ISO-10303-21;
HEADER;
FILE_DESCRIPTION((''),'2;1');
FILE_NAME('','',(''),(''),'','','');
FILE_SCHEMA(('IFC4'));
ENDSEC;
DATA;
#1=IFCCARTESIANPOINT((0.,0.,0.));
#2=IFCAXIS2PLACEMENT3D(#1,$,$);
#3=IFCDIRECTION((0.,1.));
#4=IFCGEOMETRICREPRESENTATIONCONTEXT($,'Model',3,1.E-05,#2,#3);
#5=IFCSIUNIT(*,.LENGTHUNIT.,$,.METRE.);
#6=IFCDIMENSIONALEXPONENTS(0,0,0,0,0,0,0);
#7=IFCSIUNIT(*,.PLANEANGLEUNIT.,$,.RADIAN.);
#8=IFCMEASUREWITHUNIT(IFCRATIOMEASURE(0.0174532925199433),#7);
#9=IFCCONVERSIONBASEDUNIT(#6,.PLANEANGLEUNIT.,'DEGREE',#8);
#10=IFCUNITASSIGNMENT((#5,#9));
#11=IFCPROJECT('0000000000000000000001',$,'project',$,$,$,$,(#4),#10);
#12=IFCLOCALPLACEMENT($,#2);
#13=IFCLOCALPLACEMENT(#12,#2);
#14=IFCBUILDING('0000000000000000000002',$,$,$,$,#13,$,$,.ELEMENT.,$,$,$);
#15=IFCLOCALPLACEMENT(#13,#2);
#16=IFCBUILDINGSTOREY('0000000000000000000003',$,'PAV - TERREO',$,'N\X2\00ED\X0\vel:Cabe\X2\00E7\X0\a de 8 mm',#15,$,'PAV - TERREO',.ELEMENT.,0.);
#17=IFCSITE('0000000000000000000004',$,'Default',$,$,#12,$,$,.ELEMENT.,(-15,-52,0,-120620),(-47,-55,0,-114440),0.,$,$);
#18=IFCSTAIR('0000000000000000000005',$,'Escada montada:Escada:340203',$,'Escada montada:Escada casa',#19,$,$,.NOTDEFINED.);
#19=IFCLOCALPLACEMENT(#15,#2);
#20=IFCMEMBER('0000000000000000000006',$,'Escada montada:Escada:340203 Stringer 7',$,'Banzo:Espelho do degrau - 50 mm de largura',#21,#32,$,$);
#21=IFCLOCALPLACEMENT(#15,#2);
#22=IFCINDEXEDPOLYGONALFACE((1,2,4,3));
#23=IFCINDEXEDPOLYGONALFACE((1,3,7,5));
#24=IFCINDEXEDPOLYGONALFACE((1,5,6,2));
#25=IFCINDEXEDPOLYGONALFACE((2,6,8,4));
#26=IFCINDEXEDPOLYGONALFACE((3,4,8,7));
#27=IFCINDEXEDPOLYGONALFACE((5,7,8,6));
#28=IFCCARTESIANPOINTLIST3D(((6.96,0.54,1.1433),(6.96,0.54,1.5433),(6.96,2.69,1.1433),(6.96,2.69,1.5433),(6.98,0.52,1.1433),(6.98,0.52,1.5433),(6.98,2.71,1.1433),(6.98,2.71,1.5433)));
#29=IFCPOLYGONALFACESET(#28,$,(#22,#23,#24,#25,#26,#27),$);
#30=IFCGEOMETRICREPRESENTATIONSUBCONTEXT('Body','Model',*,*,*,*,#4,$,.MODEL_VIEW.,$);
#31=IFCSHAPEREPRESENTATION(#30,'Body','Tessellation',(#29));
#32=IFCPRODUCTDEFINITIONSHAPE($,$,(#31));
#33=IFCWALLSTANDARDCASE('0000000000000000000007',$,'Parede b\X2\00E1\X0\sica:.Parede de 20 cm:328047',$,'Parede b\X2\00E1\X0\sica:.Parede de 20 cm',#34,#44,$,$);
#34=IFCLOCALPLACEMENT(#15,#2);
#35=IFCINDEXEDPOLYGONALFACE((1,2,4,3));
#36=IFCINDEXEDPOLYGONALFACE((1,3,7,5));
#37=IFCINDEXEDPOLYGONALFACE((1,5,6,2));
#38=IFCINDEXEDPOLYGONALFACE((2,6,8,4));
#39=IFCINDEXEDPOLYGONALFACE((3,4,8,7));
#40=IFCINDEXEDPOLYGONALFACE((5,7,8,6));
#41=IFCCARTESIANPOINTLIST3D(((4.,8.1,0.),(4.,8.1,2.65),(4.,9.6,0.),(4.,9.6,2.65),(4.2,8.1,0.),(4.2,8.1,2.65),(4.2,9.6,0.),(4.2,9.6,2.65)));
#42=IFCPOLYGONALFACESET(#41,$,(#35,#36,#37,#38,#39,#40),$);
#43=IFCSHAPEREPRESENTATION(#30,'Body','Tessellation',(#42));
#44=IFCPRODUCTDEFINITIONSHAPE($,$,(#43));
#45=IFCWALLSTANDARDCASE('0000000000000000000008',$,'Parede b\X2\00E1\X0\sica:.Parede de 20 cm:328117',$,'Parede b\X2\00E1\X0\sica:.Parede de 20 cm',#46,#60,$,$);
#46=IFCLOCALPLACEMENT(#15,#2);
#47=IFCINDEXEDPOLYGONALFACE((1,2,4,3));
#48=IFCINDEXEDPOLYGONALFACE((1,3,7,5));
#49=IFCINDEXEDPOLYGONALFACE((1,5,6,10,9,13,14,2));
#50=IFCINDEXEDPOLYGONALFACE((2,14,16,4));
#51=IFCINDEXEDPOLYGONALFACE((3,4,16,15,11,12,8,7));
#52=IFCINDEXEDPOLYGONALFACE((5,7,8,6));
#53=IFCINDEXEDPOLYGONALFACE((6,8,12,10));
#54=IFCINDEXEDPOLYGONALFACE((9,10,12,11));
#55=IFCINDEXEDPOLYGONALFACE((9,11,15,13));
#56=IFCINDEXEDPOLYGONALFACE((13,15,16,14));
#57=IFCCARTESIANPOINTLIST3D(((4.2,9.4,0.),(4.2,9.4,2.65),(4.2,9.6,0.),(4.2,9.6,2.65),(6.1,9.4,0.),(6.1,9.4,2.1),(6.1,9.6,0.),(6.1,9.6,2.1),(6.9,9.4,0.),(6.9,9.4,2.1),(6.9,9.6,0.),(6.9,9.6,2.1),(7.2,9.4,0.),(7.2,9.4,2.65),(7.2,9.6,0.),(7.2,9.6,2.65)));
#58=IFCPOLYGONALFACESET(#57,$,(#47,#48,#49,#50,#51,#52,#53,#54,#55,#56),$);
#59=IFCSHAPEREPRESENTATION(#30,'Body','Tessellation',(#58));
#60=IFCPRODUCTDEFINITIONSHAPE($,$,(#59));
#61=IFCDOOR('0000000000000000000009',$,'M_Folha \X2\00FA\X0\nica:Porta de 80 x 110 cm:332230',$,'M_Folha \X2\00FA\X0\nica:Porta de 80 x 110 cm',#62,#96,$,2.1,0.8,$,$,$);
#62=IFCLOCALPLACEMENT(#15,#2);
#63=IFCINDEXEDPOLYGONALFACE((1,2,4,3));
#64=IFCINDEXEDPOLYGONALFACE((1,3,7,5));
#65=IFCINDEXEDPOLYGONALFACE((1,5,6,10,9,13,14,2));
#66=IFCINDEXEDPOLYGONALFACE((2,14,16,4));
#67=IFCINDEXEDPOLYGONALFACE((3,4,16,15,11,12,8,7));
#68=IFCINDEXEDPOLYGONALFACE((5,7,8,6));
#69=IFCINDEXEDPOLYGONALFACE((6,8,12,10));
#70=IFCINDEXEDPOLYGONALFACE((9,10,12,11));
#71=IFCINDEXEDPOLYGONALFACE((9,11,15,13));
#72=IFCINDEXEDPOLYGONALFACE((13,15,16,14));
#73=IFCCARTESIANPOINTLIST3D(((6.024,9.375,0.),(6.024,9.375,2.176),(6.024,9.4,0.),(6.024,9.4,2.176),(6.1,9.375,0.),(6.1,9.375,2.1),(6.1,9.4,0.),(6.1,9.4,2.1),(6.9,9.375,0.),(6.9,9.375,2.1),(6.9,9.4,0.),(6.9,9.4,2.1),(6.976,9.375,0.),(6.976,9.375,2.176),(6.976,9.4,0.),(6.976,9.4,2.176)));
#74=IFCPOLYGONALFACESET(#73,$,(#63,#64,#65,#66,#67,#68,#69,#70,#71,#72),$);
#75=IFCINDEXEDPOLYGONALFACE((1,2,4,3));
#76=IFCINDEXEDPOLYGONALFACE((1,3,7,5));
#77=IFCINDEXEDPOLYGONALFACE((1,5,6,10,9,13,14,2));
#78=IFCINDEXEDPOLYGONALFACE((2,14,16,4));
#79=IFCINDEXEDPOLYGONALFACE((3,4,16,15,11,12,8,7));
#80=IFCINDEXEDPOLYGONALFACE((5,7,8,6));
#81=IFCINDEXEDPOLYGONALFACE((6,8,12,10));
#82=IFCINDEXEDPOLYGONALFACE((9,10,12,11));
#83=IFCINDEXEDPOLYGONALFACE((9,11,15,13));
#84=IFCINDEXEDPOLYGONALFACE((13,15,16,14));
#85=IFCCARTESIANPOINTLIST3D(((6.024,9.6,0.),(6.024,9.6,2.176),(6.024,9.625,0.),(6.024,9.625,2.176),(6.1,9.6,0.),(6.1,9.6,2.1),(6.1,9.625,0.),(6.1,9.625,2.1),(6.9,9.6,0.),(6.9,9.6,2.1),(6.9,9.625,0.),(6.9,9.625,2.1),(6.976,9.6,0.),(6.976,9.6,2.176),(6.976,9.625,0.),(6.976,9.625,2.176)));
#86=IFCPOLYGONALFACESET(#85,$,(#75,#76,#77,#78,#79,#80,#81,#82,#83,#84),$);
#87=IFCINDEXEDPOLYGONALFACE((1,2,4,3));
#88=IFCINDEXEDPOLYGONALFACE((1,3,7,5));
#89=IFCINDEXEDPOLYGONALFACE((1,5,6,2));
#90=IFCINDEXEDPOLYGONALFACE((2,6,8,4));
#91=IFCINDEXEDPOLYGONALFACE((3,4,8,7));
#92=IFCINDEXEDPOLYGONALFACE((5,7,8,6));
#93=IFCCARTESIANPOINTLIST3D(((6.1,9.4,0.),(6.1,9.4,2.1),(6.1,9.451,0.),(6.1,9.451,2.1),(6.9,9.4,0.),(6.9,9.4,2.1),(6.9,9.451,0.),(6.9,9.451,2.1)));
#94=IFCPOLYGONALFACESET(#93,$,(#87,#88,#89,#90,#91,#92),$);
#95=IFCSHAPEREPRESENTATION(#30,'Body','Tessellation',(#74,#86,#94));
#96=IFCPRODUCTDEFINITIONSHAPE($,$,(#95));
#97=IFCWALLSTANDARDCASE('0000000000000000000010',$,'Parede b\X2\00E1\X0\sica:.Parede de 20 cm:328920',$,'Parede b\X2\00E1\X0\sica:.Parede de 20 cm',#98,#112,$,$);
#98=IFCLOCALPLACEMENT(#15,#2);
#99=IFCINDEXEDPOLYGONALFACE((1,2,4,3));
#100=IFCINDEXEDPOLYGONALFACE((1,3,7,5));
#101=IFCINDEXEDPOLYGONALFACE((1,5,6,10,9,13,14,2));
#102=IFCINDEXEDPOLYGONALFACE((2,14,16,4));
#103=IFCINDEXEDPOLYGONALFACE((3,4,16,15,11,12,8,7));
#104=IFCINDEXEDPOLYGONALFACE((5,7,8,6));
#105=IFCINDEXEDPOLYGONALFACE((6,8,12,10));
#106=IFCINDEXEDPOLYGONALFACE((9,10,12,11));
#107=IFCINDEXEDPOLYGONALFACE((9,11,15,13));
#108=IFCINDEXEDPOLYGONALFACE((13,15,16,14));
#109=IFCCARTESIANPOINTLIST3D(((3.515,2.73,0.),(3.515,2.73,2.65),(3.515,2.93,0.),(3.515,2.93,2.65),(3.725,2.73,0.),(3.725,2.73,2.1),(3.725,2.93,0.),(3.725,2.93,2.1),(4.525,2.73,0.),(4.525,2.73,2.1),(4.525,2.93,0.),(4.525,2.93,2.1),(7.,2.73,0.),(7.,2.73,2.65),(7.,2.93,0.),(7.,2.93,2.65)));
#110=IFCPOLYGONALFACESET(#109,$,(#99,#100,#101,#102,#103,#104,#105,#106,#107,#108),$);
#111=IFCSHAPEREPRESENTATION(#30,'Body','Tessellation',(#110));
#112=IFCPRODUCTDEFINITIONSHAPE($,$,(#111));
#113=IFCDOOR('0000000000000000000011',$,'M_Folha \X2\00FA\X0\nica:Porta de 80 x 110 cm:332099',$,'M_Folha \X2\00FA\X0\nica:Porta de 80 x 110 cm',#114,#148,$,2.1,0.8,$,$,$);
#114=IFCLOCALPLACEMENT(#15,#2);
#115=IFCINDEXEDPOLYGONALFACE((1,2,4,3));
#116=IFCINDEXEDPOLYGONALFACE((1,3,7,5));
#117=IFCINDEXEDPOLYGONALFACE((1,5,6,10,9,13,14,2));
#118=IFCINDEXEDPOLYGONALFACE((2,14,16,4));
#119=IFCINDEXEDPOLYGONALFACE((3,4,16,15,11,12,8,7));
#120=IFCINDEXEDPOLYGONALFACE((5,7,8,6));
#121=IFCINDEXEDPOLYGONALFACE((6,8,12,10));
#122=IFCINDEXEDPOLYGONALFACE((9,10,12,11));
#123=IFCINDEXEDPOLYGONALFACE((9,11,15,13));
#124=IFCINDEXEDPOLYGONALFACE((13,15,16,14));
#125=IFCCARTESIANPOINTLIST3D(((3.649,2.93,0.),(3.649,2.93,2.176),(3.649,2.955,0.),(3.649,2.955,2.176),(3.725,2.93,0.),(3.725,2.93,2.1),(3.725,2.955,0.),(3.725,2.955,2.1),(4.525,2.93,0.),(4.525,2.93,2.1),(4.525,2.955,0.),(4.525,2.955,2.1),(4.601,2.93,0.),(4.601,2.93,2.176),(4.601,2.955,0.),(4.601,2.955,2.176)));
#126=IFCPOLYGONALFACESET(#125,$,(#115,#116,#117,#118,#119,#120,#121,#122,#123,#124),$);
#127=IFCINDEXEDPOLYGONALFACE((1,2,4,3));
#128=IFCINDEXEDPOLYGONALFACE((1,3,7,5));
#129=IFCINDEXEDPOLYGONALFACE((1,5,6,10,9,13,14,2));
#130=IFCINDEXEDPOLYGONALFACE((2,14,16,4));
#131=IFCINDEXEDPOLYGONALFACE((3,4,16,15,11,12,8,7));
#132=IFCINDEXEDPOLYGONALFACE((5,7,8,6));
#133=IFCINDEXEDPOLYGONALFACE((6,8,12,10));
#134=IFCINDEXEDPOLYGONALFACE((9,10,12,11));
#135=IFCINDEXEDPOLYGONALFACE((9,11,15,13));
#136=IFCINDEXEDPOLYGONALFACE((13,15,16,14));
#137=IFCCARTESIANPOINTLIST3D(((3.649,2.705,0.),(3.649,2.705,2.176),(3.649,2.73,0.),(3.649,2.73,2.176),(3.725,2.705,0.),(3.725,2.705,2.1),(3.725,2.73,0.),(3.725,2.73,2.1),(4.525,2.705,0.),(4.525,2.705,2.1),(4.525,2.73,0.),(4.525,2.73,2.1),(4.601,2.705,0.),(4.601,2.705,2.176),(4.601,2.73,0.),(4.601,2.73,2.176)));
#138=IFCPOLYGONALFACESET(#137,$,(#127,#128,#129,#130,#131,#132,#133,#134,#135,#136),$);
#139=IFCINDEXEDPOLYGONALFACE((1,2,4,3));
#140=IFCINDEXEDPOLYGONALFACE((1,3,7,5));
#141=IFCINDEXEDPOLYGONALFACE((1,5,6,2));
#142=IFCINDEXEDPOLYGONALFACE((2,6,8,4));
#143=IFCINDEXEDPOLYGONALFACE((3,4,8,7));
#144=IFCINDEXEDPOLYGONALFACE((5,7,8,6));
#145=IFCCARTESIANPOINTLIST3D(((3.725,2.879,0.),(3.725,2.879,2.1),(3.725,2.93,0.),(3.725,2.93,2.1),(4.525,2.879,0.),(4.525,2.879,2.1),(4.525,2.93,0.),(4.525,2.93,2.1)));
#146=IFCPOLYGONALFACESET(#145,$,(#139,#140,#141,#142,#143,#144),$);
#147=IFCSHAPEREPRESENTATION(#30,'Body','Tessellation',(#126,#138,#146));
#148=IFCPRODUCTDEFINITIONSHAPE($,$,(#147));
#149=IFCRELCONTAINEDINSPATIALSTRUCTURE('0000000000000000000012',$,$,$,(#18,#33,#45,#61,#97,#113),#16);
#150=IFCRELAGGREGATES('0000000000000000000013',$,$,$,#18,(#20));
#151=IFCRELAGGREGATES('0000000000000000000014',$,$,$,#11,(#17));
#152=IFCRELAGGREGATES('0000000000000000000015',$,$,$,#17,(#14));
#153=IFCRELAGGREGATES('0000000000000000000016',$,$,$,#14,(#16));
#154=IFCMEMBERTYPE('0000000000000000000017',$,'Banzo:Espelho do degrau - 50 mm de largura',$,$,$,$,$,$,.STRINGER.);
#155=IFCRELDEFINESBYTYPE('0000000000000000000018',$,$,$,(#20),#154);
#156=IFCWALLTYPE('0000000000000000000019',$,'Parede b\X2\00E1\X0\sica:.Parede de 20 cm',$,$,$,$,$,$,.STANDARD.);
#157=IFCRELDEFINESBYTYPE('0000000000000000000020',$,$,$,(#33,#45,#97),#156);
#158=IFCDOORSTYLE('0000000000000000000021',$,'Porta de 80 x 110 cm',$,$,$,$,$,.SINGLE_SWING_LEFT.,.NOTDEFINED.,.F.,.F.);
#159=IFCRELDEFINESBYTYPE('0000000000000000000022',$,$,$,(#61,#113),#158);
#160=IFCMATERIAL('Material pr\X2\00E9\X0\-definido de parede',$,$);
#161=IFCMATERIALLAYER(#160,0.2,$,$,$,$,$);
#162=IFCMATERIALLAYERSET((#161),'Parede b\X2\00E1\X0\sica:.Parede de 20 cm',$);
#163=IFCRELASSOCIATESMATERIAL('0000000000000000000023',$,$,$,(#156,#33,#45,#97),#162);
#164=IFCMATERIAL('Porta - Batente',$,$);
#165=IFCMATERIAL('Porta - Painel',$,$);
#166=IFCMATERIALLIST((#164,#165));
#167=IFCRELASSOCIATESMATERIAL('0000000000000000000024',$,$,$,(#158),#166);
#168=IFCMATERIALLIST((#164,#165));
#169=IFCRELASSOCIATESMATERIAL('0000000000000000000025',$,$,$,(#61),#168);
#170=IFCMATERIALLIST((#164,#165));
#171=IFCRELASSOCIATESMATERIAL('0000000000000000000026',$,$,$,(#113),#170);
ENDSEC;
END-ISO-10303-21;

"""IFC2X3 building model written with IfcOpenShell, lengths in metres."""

from ifc_helpers import new_model, entity, si_unit, converted_unit, direction, frame, frame_2d, origin, place, context, subcontext, project, spatial, polyline, rectangle, outline, extrude, clip, bounded_halfspace, source, transform, mapped, material, material_list, layer, layer_set, layer_usage, type_object, type_shapes, element, fill, aggregate, save


model = new_model("IFC2X3")

# Units and contexts
model_context = context("Model", 3, precision=1e-05, world=origin(), true_north=direction((0.0, 1.0)))
body_context = subcontext(model_context, "Body", "Model", "MODEL_VIEW")
ifc_project = project(units=[si_unit("LENGTHUNIT", "METRE"), converted_unit("PLANEANGLEUNIT", "DEGREE", entity("IfcRatioMeasure", 0.0174532925199433), si_unit("PLANEANGLEUNIT", "RADIAN"), dimensions=[0, 0, 0, 0, 0, 0, 0])], contexts=[model_context])

# Site, building, storey
site_placement = place(None, origin())
site = spatial("IfcSite", under=ifc_project, at=site_placement, Name="Default", CompositionType="ELEMENT", RefLatitude=(-15, -52, 0, -120620), RefLongitude=(-47, -55, 0, -114440), RefElevation=0.0)
building_placement = place(site_placement, origin())
building = spatial("IfcBuilding", under=site, at=building_placement, CompositionType="ELEMENT")
storey_placement = place(building_placement, origin())
storey = spatial("IfcBuildingStorey", under=building, at=storey_placement, Name="PAV - TERREO", ObjectType="Nível:Cabeça de 8 mm", LongName="PAV - TERREO", CompositionType="ELEMENT", Elevation=0.0)

# Stair, member
stair_placement = place(storey_placement, origin())
stair = element("IfcStair", 1, at=stair_placement, inside=storey, Name="Escada montada:Escada:340203", ObjectType="Escada montada:Escada casa", ShapeType="NOTDEFINED")
member_type = type_object("IfcMemberType", Name="Banzo:Espelho do degrau - 50 mm de largura", PredefinedType="STRINGER")
member_placement = place(stair_placement, origin())
member = element("IfcMember", 2, at=member_placement, type_object=member_type, Name="Escada montada:Escada:340203 Stringer 7", ObjectType="Banzo:Espelho do degrau - 50 mm de largura", context=body_context, shape_type="SweptSolid", body=[
    extrude(outline(polyline([(-1.095, -0.01), (1.095, -0.01), (1.075, 0.01), (-1.075, 0.01), (-1.095, -0.01)])), frame((6.97, 1.615, 1.1433), z_axis=(0.0, 0.0, 1.0), x_axis=(0.0, 1.0, 0.0)), (0.0, 0.0, 1.0), 0.4),
])
aggregate(stair, [member])

# Shared definitions
ifc_material_1 = material(Name="Material pré-definido de parede")
ifc_layer_1 = layer(ifc_material_1, 0.2)
ifc_layer_set_1 = layer_set([ifc_layer_1], Name="Parede básica:.Parede de 20 cm")
wall_type_1 = type_object("IfcWallType", Name="Parede básica:.Parede de 20 cm", PredefinedType="STANDARD", material=ifc_layer_set_1)
ifc_material_2 = material(Name="Porta - Batente")
ifc_material_3 = material(Name="Porta - Painel")
ifc_material_list_1 = material_list([ifc_material_2, ifc_material_3])
door_style_1 = type_object("IfcDoorStyle", Name="Porta de 80 x 110 cm", ConstructionType="NOTDEFINED", OperationType="SINGLE_SWING_LEFT", ParameterTakesPrecedence=False, Sizeable=False, material=ifc_material_list_1)
shared_shape_1 = source(origin(), body_context, "Body", "SweptSolid", [
    extrude(outline(polyline([(-0.476, -1.107), (0.476, -1.107), (0.476, 1.069), (0.4, 1.069), (0.4, -1.031), (-0.4, -1.031), (-0.4, 1.069), (-0.476, 1.069), (-0.476, -1.107)])), frame((0.4, 0.225, 1.069), z_axis=(0.0, -1.0, 0.0), x_axis=(-1.0, 0.0, 0.0)), (0.0, 0.0, 1.0), 0.025),
    extrude(outline(polyline([(-1.107, -0.476), (1.069, -0.476), (1.069, -0.4), (-1.031, -0.4), (-1.031, 0.4), (1.069, 0.4), (1.069, 0.476), (-1.107, 0.476), (-1.107, -0.476)])), frame((0.4, 0.0, 1.069), z_axis=(0.0, -1.0, 0.0), x_axis=(0.0, 0.0, -1.0)), (0.0, 0.0, 1.0), 0.025),
    extrude(rectangle(XDim=0.8, YDim=0.051, at=frame_2d((0.0, 0.0), x_axis=(1.0, 0.0))), frame((0.4, 0.1745, 0.0)), (0.0, 0.0, 1.0), 2.1),
])
type_shapes(door_style_1, [shared_shape_1])

# Wall
ifc_layer_usage_1 = layer_usage(ifc_layer_set_1, "AXIS2", "NEGATIVE", 0.1)
wall_1_placement = place(storey_placement, frame((4.1, 8.1, 0.0), z_axis=(0.0, 0.0, 1.0), x_axis=(0.0, 1.0, 0.0)))
element("IfcWallStandardCase", 3, at=wall_1_placement, inside=storey, type_object=wall_type_1, material=ifc_layer_usage_1, Name="Parede básica:.Parede de 20 cm:328047", ObjectType="Parede básica:.Parede de 20 cm", context=body_context, shape_type="Clipping", body=[
    clip(extrude(rectangle(XDim=1.5, YDim=0.2, at=frame_2d((0.75, 0.0), x_axis=(-1.0, 0.0))), origin(), (0.0, 0.0, 1.0), 2.65), bounded_halfspace(frame((0.0, -0.1, 2.65), z_axis=(0.0, 0.0, -1.0), x_axis=(-1.0, 0.0, 0.0)), True, frame((0.0, -0.1, 2.65)), polyline([(0.0, 0.0), (1.3, 0.0), (1.5, 0.0), (1.5, 0.2), (0.0, 0.2), (0.0, 0.0)]))),
])

# Wall, opening, door
ifc_layer_usage_2 = layer_usage(ifc_layer_set_1, "AXIS2", "NEGATIVE", 0.1)
wall_2_placement = place(storey_placement, frame((4.2, 9.5, 0.0)))
wall_2 = element("IfcWallStandardCase", 4, at=wall_2_placement, inside=storey, type_object=wall_type_1, material=ifc_layer_usage_2, Name="Parede básica:.Parede de 20 cm:328117", ObjectType="Parede básica:.Parede de 20 cm", context=body_context, shape_type="Clipping", body=[
    clip(extrude(rectangle(XDim=3.0, YDim=0.2, at=frame_2d((1.5, 0.0), x_axis=(-1.0, 0.0))), origin(), (0.0, 0.0, 1.0), 2.65), bounded_halfspace(frame((0.0, -0.1, 2.65), z_axis=(0.0, 0.0, -1.0), x_axis=(0.0, -1.0, 0.0)), True, frame((0.0, -0.1, 2.65)), polyline([(0.0, 0.0), (2.8, 0.0), (3.0, 0.0), (3.0, 0.2), (0.0, 0.2), (0.0, 0.0)]))),
])
opening_1_placement = place(wall_2_placement, frame((2.7, 0.1, 0.0)))
opening_1 = element("IfcOpeningElement", 5, at=opening_1_placement, cuts=wall_2, ObjectType="Opening", context=body_context, shape_type="SweptSolid", body=[
    extrude(rectangle(XDim=0.8, YDim=2.1, at=frame_2d((1.05, 0.4), x_axis=(0.0, -1.0))), frame((0.0, 0.0, 0.0), z_axis=(0.0, -1.0, 0.0), x_axis=(0.0, 0.0, 1.0)), (0.0, 0.0, 1.0), 0.2),
])
ifc_material_list_2 = material_list([ifc_material_2, ifc_material_3])
door_1_placement = place(opening_1_placement, frame((0.0, 0.0, 0.0), z_axis=(0.0, 0.0, 1.0), x_axis=(-1.0, 0.0, 0.0)))
door_1 = element("IfcDoor", 6, at=door_1_placement, inside=storey, type_object=door_style_1, material=ifc_material_list_2, Name="M_Folha única:Porta de 80 x 110 cm:332230", ObjectType="M_Folha única:Porta de 80 x 110 cm", OverallHeight=2.1, OverallWidth=0.8, context=body_context, shape_type="MappedRepresentation", body=[
    mapped(shared_shape_1, transform((0.0, 0.0, 0.0), scale=1.0)),
])
fill(opening_1, door_1)

# Wall, opening, door
ifc_layer_usage_3 = layer_usage(ifc_layer_set_1, "AXIS2", "NEGATIVE", 0.1)
wall_3_placement = place(storey_placement, frame((7.0, 2.83, 0.0), z_axis=(0.0, 0.0, 1.0), x_axis=(-1.0, 0.0, 0.0)))
wall_3 = element("IfcWallStandardCase", 7, at=wall_3_placement, inside=storey, type_object=wall_type_1, material=ifc_layer_usage_3, Name="Parede básica:.Parede de 20 cm:328920", ObjectType="Parede básica:.Parede de 20 cm", context=body_context, shape_type="Clipping", body=[
    clip(extrude(rectangle(XDim=3.485, YDim=0.2, at=frame_2d((1.7425, 0.0), x_axis=(-1.0, 0.0))), origin(), (0.0, 0.0, 1.0), 2.65), bounded_halfspace(frame((0.0, -0.1, 2.65), z_axis=(0.0, 0.0, -1.0), x_axis=(0.0, 1.0, 0.0)), True, frame((0.0, -0.1, 2.65)), polyline([(0.0, 0.0), (1.405, 0.0), (1.555, 0.0), (3.335, 0.0), (3.485, 0.0), (3.485, 0.2), (0.0, 0.2), (0.0, 0.0)]))),
])
opening_2_placement = place(wall_3_placement, frame((3.275, 0.1, 0.0)))
opening_2 = element("IfcOpeningElement", 8, at=opening_2_placement, cuts=wall_3, ObjectType="Opening", context=body_context, shape_type="SweptSolid", body=[
    extrude(rectangle(XDim=0.8, YDim=2.1, at=frame_2d((1.05, 0.4), x_axis=(0.0, -1.0))), frame((0.0, 0.0, 0.0), z_axis=(0.0, -1.0, 0.0), x_axis=(0.0, 0.0, 1.0)), (0.0, 0.0, 1.0), 0.2),
])
ifc_material_list_3 = material_list([ifc_material_2, ifc_material_3])
door_2_placement = place(opening_2_placement, frame((0.0, 0.0, 0.0), z_axis=(0.0, 0.0, 1.0), x_axis=(-1.0, 0.0, 0.0)))
door_2 = element("IfcDoor", 9, at=door_2_placement, inside=storey, type_object=door_style_1, material=ifc_material_list_3, Name="M_Folha única:Porta de 80 x 110 cm:332099", ObjectType="M_Folha única:Porta de 80 x 110 cm", OverallHeight=2.1, OverallWidth=0.8, context=body_context, shape_type="MappedRepresentation", body=[
    mapped(shared_shape_1, transform((0.0, 0.0, 0.0), scale=1.0)),
])
fill(opening_2, door_2)

save(model, "model.ifc")
